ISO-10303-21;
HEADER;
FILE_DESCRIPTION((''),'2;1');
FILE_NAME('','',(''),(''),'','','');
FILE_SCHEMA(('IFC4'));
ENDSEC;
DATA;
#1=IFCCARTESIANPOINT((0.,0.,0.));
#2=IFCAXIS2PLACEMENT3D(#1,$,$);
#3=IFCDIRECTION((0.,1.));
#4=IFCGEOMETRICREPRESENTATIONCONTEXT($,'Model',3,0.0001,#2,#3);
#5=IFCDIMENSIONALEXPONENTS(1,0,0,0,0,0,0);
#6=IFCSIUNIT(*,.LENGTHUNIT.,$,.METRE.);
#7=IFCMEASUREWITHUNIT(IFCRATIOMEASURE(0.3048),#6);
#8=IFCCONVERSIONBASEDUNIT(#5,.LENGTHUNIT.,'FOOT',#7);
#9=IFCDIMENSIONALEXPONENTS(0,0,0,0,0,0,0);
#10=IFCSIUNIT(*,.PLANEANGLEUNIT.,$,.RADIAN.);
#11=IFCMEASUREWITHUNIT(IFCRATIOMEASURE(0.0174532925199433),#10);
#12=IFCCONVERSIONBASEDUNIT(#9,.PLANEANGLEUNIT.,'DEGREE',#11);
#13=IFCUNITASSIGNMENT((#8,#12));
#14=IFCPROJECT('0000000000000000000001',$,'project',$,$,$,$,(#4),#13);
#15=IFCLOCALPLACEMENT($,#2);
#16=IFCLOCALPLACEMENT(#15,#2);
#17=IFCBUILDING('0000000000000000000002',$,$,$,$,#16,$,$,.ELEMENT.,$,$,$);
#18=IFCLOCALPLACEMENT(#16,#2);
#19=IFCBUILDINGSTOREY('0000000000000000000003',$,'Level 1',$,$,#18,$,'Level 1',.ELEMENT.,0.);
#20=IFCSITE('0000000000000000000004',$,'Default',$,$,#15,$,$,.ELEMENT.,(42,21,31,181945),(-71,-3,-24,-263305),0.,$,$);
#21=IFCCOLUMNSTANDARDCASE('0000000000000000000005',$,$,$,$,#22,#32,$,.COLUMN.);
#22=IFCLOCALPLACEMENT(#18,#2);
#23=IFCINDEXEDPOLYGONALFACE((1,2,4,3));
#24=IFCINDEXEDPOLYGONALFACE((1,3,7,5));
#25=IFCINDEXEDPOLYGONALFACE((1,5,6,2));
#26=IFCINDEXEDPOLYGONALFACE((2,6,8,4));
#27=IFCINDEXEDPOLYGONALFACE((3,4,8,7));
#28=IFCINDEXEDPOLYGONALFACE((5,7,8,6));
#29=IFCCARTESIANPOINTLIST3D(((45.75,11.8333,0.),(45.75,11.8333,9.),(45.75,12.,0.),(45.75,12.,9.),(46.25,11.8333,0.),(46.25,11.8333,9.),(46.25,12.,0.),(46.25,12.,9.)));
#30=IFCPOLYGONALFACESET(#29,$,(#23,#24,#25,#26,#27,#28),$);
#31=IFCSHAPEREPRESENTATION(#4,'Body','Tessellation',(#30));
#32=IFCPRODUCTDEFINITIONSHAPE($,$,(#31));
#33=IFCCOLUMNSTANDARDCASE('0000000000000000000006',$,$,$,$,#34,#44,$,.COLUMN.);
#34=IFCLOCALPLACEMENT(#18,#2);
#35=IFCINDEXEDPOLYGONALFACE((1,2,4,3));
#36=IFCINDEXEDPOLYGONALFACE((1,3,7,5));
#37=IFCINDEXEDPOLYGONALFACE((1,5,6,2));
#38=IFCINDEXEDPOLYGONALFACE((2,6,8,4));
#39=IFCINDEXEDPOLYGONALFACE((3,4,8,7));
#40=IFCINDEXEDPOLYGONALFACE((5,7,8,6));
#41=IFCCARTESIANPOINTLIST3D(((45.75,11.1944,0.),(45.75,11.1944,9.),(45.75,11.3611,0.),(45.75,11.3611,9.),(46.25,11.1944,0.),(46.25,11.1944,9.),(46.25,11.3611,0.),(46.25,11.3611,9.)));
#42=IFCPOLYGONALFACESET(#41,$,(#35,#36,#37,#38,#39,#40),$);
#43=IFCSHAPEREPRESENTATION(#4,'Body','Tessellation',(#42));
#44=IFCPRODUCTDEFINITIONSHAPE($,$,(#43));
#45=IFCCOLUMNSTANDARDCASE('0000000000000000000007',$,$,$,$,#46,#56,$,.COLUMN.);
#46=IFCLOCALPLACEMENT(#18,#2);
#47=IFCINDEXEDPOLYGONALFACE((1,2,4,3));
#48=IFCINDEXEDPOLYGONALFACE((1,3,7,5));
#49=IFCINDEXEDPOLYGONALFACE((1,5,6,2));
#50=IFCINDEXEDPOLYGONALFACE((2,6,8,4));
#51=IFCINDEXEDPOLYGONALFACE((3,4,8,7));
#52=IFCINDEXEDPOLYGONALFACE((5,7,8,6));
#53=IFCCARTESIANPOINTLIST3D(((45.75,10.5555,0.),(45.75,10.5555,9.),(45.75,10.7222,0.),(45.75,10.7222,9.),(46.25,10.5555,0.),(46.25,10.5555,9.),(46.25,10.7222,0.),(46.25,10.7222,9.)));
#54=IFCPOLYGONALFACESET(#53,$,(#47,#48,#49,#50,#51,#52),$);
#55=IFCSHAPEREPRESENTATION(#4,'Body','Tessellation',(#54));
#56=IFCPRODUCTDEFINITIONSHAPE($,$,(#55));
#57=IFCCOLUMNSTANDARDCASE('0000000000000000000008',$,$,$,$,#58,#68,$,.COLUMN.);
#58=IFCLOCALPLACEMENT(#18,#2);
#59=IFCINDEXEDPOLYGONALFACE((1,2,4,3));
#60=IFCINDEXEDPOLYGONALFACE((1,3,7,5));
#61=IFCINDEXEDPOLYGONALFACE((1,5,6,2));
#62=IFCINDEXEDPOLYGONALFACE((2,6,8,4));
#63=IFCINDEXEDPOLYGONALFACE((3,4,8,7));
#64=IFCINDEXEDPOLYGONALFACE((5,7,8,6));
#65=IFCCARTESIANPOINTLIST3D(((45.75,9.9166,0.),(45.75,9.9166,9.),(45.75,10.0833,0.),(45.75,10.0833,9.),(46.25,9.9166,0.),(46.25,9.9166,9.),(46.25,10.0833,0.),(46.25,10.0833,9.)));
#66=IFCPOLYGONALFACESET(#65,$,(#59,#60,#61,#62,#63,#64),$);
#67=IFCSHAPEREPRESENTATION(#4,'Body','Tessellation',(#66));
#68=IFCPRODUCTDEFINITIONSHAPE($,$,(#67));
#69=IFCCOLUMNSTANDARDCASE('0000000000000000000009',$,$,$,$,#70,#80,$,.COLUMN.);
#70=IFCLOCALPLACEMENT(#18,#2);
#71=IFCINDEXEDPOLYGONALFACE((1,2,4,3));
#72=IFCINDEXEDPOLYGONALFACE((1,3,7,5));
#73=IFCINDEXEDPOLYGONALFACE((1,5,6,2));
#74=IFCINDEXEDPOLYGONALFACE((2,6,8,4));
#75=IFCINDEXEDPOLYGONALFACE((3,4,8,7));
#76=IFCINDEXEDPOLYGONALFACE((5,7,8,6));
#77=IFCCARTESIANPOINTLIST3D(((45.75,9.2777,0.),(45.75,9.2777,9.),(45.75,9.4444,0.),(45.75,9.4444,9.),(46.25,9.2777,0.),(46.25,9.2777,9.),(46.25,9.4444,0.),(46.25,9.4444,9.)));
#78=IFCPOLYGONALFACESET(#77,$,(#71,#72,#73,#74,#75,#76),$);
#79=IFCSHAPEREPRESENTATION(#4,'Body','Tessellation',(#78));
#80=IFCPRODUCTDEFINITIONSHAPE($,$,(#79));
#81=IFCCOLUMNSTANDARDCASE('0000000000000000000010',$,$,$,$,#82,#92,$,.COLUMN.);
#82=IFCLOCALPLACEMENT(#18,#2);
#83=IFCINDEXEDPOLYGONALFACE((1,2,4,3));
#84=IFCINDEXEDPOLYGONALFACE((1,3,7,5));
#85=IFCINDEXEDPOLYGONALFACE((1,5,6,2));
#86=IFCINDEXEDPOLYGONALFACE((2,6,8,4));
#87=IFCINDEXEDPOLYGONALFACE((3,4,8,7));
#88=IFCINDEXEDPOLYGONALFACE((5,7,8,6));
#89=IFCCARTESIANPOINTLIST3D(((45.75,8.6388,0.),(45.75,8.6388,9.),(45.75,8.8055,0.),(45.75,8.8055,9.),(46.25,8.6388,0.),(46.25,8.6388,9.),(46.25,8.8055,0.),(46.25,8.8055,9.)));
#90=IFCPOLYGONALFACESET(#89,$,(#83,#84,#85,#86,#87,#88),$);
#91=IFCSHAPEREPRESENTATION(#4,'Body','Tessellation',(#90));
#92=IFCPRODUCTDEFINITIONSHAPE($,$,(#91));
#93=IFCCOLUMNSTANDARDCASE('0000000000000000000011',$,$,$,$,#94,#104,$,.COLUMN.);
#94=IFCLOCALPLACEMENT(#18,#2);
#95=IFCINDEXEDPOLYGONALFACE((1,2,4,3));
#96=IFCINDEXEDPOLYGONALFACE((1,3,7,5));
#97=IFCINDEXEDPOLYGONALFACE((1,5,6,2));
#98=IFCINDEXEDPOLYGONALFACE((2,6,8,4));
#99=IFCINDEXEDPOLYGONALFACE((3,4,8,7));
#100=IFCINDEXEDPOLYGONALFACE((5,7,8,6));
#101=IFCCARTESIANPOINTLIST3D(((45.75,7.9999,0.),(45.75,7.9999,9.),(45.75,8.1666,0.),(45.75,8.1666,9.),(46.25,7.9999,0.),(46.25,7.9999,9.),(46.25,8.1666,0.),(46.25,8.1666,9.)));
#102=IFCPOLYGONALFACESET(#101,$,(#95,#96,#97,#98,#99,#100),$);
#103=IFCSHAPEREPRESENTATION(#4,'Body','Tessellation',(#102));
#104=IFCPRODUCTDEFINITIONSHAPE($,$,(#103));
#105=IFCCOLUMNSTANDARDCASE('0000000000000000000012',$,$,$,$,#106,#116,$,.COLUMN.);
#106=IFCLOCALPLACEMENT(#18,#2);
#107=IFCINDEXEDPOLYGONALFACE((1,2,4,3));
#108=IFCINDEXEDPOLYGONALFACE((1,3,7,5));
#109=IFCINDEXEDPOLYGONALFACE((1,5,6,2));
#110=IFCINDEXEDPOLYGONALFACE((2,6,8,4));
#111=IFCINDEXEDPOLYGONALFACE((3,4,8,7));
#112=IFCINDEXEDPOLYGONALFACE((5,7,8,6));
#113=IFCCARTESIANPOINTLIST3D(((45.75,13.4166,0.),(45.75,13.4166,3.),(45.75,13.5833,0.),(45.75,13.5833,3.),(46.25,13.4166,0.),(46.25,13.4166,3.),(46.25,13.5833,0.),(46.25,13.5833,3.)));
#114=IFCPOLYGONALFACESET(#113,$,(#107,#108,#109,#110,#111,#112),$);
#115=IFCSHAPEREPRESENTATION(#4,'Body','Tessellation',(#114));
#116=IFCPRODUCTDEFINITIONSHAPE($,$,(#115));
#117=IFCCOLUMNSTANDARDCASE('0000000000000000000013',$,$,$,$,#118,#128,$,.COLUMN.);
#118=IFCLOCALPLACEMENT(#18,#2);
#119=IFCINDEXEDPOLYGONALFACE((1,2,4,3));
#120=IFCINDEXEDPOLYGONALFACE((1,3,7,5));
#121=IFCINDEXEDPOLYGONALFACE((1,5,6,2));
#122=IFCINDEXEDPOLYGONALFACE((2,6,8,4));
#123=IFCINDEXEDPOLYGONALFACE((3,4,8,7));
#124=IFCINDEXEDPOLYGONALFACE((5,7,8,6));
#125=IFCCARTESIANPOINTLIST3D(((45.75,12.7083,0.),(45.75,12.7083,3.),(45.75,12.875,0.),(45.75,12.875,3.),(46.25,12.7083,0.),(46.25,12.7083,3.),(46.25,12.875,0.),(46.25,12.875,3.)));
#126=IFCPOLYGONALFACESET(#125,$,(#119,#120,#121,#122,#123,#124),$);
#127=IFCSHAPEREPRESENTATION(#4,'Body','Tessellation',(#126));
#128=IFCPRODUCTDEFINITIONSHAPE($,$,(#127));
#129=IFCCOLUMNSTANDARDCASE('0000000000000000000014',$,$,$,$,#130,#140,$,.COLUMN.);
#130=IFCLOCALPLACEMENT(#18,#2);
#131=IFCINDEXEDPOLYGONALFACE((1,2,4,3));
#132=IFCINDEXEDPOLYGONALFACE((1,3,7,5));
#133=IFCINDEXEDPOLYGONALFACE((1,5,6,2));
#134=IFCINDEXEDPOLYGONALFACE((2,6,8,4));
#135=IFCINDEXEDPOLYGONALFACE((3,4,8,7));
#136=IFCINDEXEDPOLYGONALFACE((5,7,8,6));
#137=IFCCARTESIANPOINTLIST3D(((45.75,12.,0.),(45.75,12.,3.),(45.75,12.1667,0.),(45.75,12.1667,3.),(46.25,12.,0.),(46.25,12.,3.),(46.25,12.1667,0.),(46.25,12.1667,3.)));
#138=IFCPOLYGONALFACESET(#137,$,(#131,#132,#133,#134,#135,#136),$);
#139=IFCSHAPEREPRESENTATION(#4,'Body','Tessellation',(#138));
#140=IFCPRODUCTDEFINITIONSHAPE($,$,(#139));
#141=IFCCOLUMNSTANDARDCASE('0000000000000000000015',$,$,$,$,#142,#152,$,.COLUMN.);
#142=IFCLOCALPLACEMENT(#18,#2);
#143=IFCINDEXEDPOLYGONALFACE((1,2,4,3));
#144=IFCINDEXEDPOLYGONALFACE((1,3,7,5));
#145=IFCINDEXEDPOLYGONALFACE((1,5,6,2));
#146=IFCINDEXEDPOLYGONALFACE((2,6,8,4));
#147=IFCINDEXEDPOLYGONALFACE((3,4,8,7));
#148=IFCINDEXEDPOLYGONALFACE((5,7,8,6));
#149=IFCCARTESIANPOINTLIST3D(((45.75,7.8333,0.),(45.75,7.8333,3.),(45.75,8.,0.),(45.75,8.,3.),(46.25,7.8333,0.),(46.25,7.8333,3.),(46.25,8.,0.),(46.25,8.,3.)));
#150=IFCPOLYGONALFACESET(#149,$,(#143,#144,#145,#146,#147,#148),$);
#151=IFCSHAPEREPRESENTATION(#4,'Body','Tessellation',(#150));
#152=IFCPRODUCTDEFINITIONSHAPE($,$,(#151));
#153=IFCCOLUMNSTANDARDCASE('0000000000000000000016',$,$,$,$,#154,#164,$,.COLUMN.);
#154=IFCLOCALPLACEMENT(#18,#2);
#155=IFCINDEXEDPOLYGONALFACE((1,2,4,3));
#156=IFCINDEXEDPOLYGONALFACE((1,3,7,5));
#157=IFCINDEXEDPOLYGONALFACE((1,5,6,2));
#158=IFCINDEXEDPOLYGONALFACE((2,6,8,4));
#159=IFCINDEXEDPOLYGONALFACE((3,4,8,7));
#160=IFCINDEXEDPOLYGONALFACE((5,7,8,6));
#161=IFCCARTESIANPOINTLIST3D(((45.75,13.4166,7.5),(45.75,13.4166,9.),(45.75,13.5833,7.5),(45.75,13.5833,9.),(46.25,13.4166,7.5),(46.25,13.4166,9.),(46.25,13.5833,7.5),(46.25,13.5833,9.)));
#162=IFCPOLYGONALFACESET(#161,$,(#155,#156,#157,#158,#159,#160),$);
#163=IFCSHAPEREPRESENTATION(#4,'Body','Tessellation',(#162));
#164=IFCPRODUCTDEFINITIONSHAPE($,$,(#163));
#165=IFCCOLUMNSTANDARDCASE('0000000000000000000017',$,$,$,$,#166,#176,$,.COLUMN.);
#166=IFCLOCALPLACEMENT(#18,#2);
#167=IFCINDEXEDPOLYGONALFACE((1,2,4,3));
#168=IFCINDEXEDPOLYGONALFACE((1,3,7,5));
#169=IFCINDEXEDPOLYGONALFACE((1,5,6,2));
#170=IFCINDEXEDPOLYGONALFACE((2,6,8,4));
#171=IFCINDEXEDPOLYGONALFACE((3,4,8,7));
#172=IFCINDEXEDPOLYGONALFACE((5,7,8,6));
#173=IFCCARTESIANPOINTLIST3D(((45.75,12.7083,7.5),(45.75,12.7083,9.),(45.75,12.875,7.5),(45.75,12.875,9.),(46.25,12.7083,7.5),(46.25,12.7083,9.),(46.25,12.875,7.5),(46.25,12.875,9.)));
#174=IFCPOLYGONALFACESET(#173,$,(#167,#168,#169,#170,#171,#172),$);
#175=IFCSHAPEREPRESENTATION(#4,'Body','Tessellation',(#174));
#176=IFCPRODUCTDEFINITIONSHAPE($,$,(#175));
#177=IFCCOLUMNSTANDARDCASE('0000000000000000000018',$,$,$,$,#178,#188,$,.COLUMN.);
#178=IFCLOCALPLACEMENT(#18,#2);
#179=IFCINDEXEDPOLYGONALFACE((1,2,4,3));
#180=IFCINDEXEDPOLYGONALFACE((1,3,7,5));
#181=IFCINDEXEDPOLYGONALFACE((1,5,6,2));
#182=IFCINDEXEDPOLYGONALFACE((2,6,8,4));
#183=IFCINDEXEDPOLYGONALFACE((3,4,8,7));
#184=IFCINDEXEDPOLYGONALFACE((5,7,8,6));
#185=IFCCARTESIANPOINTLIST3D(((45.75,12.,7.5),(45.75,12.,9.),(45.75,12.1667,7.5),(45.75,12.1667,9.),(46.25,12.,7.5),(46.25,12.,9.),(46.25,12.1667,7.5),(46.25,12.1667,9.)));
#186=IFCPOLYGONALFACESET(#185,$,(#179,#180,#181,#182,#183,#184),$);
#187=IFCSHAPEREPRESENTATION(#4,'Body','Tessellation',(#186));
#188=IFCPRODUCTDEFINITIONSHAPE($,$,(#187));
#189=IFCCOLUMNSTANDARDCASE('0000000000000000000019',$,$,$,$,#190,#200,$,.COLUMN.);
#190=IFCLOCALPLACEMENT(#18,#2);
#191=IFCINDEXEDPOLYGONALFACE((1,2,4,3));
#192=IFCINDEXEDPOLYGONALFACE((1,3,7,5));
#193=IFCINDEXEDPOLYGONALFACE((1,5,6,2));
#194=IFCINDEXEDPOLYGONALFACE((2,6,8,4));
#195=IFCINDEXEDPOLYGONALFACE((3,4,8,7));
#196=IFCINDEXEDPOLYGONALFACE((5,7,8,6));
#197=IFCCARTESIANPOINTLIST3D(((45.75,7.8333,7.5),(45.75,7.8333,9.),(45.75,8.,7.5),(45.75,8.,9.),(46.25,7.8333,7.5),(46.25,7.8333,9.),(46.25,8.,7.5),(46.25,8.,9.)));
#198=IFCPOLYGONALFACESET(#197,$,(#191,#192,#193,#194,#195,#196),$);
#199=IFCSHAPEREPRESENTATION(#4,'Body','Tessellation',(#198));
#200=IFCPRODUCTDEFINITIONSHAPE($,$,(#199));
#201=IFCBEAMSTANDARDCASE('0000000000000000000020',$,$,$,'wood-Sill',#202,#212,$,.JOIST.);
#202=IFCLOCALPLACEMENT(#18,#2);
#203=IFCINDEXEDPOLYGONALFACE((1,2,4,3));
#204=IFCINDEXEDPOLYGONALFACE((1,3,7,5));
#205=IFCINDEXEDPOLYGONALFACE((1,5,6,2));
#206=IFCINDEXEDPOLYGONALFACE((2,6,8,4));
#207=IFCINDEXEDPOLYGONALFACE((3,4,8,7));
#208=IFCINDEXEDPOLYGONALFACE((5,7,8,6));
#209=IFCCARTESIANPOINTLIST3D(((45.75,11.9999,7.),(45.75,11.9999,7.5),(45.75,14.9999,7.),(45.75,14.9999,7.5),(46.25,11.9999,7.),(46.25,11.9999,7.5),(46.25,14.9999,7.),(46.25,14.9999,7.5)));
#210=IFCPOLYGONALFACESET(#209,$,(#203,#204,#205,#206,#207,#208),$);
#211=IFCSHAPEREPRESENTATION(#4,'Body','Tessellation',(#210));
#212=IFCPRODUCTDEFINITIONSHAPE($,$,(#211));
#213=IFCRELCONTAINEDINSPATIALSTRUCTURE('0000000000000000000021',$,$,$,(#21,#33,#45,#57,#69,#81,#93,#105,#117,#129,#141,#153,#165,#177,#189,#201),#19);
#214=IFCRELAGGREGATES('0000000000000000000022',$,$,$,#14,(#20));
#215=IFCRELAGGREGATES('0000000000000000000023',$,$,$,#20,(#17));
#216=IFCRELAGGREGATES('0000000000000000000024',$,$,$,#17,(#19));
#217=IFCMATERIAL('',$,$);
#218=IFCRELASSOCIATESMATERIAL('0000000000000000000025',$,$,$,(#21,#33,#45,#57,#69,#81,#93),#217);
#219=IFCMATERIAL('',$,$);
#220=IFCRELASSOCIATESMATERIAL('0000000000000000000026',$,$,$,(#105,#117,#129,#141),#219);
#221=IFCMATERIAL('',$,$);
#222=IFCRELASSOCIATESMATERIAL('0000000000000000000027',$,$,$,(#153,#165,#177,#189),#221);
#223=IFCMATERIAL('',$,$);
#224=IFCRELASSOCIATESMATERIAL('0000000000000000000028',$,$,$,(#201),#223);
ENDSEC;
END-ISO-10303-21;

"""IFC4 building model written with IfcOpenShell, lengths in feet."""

from ifc_helpers import new_model, entity, si_unit, converted_unit, direction, frame, origin, place, context, project, spatial, rectangle, extrude, material, element, save


model = new_model("IFC4")

# Units and contexts
model_context = context("Model", 3, precision=0.0001, world=origin(), true_north=direction((0.0, 1.0)))
ifc_project = project(units=[converted_unit("LENGTHUNIT", "FOOT", entity("IfcRatioMeasure", 0.3048), si_unit("LENGTHUNIT", "METRE"), dimensions=[1, 0, 0, 0, 0, 0, 0]), converted_unit("PLANEANGLEUNIT", "DEGREE", entity("IfcRatioMeasure", 0.0174532925199433), si_unit("PLANEANGLEUNIT", "RADIAN"), dimensions=[0, 0, 0, 0, 0, 0, 0])], contexts=[model_context])

# Site, building, storey
site_placement = place(None, origin())
site = spatial("IfcSite", under=ifc_project, at=site_placement, Name="Default", CompositionType="ELEMENT", RefLatitude=(42, 21, 31, 181945), RefLongitude=(-71, -3, -24, -263305), RefElevation=0.0)
building_placement = place(site_placement, origin())
building = spatial("IfcBuilding", under=site, at=building_placement, CompositionType="ELEMENT")
storey_placement = place(building_placement, origin())
storey = spatial("IfcBuildingStorey", under=building, at=storey_placement, Name="Level 1", LongName="Level 1", CompositionType="ELEMENT", Elevation=0.0)

# Columns
ifc_material_1 = material(Name="")
placement_1 = place(storey_placement, frame((46.0, 46.25, 0.0), z_axis=(0.0, 0.0, 1.0), x_axis=(0.0, -1.0, 0.0)))
for number, where, z_axis, x_axis in (
    (1, (34.3334, 0.0, 0.0), (0.0, 0.0, 1.0), (1.0, 0.0, 0.0)),
    (2, (34.9723, 0.0, 0.0), (0.0, 0.0, 1.0), (1.0, 0.0, 0.0)),
    (3, (35.6112, 0.0, 0.0), (0.0, 0.0, 1.0), (1.0, 0.0, 0.0)),
    (4, (36.2501, 0.0, 0.0), (0.0, 0.0, 1.0), (1.0, 0.0, 0.0)),
    (5, (36.889, 0.0, 0.0), (0.0, 0.0, 1.0), (1.0, 0.0, 0.0)),
    (6, (37.5279, 0.0, 0.0), (0.0, 0.0, 1.0), (1.0, 0.0, 0.0)),
    (7, (38.1668, 0.0, 0.0), (0.0, 0.0, 1.0), (1.0, 0.0, 0.0)),
):
    element("IfcColumnStandardCase", number, at=place(placement_1, frame(where, z_axis=z_axis, x_axis=x_axis)), inside=storey, material=ifc_material_1, PredefinedType="COLUMN", context=model_context, shape_type="SweptSolid", body=[
        extrude(rectangle(XDim=0.1667, YDim=0.5), origin(), (0.0, 0.0, 1.0), 9.0),
    ])
ifc_material_2 = material(Name="")
for number, where, z_axis, x_axis in (
    (8, (32.7501, 0.0, 0.0), (0.0, 0.0, 1.0), (1.0, 0.0, 0.0)),
    (9, (33.4584, 0.0, 0.0), (0.0, 0.0, 1.0), (1.0, 0.0, 0.0)),
    (10, (34.1667, 0.0, 0.0), (0.0, 0.0, 1.0), (1.0, 0.0, 0.0)),
    (11, (38.3334, 0.0, 0.0), (0.0, 0.0, 1.0), (1.0, 0.0, 0.0)),
):
    element("IfcColumnStandardCase", number, at=place(placement_1, frame(where, z_axis=z_axis, x_axis=x_axis)), inside=storey, material=ifc_material_2, PredefinedType="COLUMN", context=model_context, shape_type="SweptSolid", body=[
        extrude(rectangle(XDim=0.1667, YDim=0.5), origin(), (0.0, 0.0, 1.0), 3.0),
    ])
ifc_material_3 = material(Name="")
for number, where, z_axis, x_axis in (
    (12, (32.7501, 0.0, 7.5), (0.0, 0.0, 1.0), (1.0, 0.0, 0.0)),
    (13, (33.4584, 0.0, 7.5), (0.0, 0.0, 1.0), (1.0, 0.0, 0.0)),
    (14, (34.1667, 0.0, 7.5), (0.0, 0.0, 1.0), (1.0, 0.0, 0.0)),
    (15, (38.3334, 0.0, 7.5), (0.0, 0.0, 1.0), (1.0, 0.0, 0.0)),
):
    element("IfcColumnStandardCase", number, at=place(placement_1, frame(where, z_axis=z_axis, x_axis=x_axis)), inside=storey, material=ifc_material_3, PredefinedType="COLUMN", context=model_context, shape_type="SweptSolid", body=[
        extrude(rectangle(XDim=0.1667, YDim=0.5), origin(), (0.0, 0.0, 1.0), 1.5),
    ])

# Beam
ifc_material_4 = material(Name="")
for number, where, z_axis, x_axis in (
    (16, (32.7501, 0.0, 7.0), (0.0, 0.0, 1.0), (1.0, 0.0, 0.0)),
):
    element("IfcBeamStandardCase", number, at=place(placement_1, frame(where, z_axis=z_axis, x_axis=x_axis)), inside=storey, material=ifc_material_4, ObjectType="wood-Sill", PredefinedType="JOIST", context=model_context, shape_type="SweptSolid", body=[
        extrude(rectangle(XDim=3.0, YDim=0.5), origin(), (0.0, 0.0, 1.0), 0.5),
    ])

save(model, "model.ifc")
